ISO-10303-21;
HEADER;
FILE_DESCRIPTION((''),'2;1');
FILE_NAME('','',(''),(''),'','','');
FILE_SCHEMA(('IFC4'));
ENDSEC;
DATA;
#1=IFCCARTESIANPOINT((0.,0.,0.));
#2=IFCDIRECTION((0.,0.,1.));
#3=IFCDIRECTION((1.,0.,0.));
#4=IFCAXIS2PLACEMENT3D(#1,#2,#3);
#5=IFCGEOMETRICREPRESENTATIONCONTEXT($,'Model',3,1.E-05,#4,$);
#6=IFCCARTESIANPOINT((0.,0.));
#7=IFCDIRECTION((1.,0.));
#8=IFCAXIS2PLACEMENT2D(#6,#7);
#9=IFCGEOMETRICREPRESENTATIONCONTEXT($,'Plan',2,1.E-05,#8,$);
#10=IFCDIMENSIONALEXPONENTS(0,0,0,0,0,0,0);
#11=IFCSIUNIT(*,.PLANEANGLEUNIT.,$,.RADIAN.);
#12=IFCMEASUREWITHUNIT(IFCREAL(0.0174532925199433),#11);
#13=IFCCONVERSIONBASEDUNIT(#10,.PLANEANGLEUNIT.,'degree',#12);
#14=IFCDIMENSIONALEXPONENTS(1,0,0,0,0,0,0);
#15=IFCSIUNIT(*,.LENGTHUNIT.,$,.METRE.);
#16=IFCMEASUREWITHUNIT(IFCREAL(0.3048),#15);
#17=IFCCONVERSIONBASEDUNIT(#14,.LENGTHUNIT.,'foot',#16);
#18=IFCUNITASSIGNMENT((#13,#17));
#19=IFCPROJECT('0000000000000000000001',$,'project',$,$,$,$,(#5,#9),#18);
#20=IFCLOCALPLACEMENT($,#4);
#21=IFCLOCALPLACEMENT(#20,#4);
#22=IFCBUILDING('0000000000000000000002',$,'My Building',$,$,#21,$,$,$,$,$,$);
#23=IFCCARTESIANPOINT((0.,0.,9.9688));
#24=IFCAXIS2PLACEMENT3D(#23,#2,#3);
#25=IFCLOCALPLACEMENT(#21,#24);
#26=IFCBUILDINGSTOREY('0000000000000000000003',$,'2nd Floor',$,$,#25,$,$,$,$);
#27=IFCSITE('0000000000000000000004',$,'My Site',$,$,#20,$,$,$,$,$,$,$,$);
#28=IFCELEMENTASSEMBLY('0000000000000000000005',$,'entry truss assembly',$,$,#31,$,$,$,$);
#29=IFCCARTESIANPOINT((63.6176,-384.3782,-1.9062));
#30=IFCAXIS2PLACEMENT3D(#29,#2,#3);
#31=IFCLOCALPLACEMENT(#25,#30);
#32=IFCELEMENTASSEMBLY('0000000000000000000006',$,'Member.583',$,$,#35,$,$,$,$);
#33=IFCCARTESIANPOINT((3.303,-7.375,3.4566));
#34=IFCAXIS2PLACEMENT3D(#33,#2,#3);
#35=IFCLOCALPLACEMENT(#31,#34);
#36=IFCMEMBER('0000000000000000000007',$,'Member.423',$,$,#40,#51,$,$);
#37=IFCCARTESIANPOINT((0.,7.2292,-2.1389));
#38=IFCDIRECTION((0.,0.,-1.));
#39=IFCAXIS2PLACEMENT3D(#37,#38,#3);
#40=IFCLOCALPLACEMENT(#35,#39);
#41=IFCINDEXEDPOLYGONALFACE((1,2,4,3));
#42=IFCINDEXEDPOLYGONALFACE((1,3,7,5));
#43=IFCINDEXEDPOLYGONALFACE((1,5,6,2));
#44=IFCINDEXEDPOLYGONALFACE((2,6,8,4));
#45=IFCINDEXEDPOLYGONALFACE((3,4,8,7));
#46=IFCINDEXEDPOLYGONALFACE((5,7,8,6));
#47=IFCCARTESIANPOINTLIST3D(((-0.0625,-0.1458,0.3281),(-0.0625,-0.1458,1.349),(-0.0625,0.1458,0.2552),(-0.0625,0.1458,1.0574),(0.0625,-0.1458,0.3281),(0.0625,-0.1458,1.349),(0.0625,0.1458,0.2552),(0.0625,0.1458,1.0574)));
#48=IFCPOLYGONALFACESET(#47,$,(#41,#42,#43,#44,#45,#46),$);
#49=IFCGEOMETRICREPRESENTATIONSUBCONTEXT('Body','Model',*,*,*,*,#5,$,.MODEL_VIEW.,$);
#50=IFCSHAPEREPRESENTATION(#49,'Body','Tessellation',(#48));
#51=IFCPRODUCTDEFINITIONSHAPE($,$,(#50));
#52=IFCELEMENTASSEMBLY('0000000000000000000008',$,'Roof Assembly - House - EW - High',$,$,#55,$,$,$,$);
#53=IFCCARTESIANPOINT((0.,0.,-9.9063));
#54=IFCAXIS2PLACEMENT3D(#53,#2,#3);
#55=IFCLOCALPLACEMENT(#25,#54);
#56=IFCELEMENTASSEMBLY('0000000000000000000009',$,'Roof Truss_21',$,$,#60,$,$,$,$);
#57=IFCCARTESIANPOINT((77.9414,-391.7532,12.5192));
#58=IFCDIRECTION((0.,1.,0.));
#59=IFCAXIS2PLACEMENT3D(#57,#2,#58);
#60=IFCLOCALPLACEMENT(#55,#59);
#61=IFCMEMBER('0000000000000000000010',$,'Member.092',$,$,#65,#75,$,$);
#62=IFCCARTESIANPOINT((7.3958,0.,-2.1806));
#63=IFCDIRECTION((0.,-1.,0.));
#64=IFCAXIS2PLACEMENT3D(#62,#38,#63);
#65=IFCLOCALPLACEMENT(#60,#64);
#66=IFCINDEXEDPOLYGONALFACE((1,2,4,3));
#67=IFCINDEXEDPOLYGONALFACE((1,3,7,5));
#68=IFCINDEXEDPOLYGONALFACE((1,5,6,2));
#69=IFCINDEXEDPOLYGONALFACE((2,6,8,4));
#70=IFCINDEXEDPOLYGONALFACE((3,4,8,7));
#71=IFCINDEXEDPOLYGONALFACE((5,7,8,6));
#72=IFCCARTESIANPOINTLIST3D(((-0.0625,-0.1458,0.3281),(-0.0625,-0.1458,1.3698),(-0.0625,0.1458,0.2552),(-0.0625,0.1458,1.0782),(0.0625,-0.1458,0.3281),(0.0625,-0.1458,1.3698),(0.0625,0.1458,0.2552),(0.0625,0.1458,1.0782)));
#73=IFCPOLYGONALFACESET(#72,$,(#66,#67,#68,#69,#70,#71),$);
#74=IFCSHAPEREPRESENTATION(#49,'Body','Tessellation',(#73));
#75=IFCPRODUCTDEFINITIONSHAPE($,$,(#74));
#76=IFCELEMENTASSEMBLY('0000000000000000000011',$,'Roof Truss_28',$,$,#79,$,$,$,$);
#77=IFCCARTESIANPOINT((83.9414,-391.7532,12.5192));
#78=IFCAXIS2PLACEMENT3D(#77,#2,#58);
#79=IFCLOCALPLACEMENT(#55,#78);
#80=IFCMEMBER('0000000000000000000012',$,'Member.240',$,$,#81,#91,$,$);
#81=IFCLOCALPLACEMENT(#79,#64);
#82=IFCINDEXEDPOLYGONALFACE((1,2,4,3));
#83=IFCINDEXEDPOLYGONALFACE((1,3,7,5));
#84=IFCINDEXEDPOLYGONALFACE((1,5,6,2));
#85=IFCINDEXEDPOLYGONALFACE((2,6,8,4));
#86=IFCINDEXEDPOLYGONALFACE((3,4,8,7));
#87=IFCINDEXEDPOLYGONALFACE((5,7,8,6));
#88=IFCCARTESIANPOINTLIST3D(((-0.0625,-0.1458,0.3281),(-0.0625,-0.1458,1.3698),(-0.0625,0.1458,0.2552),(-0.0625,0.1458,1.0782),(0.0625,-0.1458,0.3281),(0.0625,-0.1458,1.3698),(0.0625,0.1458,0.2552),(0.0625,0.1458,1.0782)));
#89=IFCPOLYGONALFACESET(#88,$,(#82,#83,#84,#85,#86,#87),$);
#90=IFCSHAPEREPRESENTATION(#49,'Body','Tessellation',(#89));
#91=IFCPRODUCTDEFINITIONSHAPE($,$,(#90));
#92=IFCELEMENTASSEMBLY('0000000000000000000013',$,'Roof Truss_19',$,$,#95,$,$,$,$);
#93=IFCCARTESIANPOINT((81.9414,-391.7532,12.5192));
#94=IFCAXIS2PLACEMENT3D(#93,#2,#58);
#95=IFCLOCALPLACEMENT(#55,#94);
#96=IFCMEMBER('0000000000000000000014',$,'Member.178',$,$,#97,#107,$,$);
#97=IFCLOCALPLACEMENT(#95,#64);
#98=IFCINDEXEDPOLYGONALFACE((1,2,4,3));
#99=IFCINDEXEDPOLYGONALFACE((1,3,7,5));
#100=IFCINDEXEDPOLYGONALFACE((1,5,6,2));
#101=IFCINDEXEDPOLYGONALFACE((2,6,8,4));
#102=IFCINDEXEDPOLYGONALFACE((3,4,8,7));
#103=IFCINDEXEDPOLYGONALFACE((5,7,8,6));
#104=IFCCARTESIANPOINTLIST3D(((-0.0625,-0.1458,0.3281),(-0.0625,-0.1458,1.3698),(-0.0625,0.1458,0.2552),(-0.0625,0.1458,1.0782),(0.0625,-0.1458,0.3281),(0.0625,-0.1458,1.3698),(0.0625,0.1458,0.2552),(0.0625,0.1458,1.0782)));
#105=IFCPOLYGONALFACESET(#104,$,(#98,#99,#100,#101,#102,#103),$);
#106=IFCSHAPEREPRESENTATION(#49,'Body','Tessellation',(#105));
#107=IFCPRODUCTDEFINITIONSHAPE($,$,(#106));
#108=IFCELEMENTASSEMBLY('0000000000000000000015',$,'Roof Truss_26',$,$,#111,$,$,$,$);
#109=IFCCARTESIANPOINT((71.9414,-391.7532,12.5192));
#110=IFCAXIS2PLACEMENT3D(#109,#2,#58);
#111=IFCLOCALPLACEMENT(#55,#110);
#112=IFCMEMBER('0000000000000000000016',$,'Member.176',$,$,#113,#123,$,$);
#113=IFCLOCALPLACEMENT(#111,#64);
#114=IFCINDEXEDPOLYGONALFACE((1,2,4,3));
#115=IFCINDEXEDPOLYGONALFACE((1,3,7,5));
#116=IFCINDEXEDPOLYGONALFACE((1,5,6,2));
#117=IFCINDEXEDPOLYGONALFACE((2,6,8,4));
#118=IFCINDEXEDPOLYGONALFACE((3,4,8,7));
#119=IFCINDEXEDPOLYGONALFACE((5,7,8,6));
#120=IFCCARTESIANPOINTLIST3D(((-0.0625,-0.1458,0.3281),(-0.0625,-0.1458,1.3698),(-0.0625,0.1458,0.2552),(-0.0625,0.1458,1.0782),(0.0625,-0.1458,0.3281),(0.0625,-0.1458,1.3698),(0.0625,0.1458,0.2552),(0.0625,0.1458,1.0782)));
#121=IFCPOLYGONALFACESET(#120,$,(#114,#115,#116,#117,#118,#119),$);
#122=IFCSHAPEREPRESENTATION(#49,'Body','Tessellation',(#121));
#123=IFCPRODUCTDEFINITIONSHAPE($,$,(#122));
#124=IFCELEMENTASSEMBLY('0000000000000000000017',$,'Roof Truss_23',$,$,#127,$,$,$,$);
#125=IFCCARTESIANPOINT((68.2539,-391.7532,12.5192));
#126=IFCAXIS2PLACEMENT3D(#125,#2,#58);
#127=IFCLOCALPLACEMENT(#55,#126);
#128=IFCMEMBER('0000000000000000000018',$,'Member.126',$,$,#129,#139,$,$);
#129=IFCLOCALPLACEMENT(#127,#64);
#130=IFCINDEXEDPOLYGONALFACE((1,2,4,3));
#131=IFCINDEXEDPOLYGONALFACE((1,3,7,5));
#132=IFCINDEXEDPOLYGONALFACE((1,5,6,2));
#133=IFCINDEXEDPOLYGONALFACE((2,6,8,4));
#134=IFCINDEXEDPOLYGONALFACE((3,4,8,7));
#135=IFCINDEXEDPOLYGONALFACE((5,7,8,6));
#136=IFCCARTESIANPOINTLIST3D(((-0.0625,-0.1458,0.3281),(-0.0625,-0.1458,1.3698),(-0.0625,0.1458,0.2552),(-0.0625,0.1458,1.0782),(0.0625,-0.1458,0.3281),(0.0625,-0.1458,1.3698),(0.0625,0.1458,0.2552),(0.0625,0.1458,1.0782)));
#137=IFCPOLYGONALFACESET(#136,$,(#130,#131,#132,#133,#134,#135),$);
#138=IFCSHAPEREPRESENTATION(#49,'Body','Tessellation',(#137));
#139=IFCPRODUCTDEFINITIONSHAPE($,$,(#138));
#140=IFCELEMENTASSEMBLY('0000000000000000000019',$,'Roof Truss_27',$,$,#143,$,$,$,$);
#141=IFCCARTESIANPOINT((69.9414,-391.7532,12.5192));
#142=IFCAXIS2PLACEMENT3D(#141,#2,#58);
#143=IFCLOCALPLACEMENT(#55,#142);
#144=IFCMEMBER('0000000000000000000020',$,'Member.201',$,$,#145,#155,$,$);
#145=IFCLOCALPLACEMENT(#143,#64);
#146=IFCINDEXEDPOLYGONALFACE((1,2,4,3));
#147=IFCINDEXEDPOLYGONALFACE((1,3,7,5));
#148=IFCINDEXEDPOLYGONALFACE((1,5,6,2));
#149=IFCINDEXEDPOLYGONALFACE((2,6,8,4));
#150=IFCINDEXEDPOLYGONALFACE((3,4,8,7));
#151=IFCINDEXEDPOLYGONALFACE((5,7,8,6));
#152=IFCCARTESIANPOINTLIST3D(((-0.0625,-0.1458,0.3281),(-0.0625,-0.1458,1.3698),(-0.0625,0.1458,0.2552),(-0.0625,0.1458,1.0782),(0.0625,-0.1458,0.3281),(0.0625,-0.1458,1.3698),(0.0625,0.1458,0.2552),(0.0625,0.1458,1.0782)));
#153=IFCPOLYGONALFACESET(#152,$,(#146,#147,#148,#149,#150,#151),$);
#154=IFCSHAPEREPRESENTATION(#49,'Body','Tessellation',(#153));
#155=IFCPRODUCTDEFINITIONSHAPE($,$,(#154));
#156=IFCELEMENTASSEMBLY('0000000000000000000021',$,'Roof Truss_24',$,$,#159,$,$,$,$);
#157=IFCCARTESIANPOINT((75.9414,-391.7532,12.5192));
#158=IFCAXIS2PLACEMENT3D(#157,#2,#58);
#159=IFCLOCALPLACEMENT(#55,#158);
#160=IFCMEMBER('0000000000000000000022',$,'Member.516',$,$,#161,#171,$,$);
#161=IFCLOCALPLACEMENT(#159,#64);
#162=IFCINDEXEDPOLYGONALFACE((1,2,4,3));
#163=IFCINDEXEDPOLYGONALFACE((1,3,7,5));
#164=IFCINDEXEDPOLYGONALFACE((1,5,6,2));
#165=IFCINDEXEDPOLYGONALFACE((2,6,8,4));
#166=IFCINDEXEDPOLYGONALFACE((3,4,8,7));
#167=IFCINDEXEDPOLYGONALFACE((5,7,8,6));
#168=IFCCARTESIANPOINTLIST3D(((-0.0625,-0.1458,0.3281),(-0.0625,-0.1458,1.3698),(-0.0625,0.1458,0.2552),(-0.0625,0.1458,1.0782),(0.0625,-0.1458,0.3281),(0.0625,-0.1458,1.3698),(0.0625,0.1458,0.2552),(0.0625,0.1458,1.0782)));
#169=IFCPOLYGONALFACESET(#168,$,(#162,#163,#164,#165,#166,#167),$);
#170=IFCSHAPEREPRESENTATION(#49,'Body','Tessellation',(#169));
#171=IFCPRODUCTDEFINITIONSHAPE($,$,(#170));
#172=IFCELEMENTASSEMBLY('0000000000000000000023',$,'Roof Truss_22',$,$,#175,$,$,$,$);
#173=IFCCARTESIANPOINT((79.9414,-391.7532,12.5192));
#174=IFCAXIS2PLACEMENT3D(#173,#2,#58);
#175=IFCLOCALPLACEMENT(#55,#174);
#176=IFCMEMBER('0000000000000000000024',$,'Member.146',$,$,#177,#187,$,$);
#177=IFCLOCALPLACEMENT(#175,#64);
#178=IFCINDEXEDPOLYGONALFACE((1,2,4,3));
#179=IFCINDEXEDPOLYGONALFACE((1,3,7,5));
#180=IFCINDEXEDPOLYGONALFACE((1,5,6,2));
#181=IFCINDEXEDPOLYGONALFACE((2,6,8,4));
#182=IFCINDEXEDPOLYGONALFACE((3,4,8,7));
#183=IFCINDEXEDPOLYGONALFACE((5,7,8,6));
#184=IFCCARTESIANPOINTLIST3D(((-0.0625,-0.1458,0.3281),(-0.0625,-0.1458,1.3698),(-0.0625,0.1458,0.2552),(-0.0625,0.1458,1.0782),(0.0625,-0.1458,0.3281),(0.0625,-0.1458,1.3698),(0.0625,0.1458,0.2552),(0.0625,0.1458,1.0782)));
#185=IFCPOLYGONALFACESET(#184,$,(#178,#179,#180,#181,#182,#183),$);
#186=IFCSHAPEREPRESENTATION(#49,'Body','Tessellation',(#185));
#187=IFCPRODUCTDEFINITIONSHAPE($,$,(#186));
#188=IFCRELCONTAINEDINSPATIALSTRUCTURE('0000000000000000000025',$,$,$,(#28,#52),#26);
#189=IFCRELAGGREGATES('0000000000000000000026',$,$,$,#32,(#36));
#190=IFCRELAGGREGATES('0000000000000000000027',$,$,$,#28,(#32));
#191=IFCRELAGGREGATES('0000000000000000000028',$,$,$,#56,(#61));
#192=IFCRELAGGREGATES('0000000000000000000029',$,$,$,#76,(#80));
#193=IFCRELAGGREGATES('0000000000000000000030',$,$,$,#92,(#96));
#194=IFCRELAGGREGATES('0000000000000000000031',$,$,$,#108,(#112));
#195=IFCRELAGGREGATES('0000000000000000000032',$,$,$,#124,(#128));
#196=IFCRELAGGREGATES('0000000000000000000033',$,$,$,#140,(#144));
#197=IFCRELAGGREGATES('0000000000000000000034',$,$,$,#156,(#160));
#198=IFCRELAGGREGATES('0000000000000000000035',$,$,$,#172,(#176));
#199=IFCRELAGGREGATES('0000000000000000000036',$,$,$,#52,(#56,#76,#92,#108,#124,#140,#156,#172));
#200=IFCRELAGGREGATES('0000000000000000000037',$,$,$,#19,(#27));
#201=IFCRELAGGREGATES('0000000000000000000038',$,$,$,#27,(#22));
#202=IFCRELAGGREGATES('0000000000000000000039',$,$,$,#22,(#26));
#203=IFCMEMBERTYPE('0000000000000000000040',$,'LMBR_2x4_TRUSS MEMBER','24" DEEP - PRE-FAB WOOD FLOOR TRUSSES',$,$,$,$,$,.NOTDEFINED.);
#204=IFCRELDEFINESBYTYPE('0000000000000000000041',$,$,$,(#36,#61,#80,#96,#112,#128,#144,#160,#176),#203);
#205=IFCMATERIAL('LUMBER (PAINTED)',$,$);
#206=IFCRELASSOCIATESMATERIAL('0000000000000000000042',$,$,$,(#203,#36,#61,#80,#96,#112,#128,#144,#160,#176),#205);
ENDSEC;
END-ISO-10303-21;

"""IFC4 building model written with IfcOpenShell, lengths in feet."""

from ifc_helpers import new_model, entity, si_unit, converted_unit, frame, origin_with_axes, origin_2d_with_axis, place, context, subcontext, project, spatial, indexed_curve, outline, extrude, clip, halfspace, material, material_profile, profile_set, profile_usage, type_object, element, aggregate, save


model = new_model("IFC4")

# Units and contexts
model_context = context("Model", 3, precision=1e-05, world=origin_with_axes())
plan_context = context("Plan", 2, precision=1e-05, world=origin_2d_with_axis())
body_context = subcontext(model_context, "Body", "Model", "MODEL_VIEW")
ifc_project = project(units=[converted_unit("PLANEANGLEUNIT", "degree", entity("IfcReal", 0.0174532925199433), si_unit("PLANEANGLEUNIT", "RADIAN"), dimensions=[0, 0, 0, 0, 0, 0, 0]), converted_unit("LENGTHUNIT", "foot", entity("IfcReal", 0.3048), si_unit("LENGTHUNIT", "METRE"), dimensions=[1, 0, 0, 0, 0, 0, 0])], contexts=[model_context, plan_context])

# Site, building, storey
site_placement = place(None, origin_with_axes())
site = spatial("IfcSite", under=ifc_project, at=site_placement, Name="My Site")
building_placement = place(site_placement, origin_with_axes())
building = spatial("IfcBuilding", under=site, at=building_placement, Name="My Building")
storey_placement = place(building_placement, frame((0.0, 0.0, 9.9688), z_axis=(0.0, 0.0, 1.0), x_axis=(1.0, 0.0, 0.0)))
storey = spatial("IfcBuildingStorey", under=building, at=storey_placement, Name="2nd Floor")

# Element assemblies, members
assembly_1_placement = place(storey_placement, frame((63.6176, -384.3782, -1.9062), z_axis=(0.0, 0.0, 1.0), x_axis=(1.0, 0.0, 0.0)))
assembly_1 = element("IfcElementAssembly", 1, at=assembly_1_placement, inside=storey, Name="entry truss assembly")
assembly_2_placement = place(assembly_1_placement, frame((3.303, -7.375, 3.4566), z_axis=(0.0, 0.0, 1.0), x_axis=(1.0, 0.0, 0.0)))
assembly_2 = element("IfcElementAssembly", 2, at=assembly_2_placement, Name="Member.583")
ifc_material_1 = material(Name="LUMBER (PAINTED)")
ifc_material_profile_1 = material_profile(ifc_material_1, outline(indexed_curve([(-0.0625, -0.1458), (0.0625, -0.1458), (0.0625, 0.1458), (-0.0625, 0.1458), (-0.0625, -0.1458)])))
ifc_profile_set_1 = profile_set([ifc_material_profile_1])
member_type_1 = type_object("IfcMemberType", Name="LMBR_2x4_TRUSS MEMBER", Description="24\" DEEP - PRE-FAB WOOD FLOOR TRUSSES", PredefinedType="NOTDEFINED", material=ifc_profile_set_1)
ifc_profile_usage_1 = profile_usage(ifc_profile_set_1)
member_1_placement = place(assembly_2_placement, frame((0.0, 7.2292, -2.1389), z_axis=(0.0, 0.0, -1.0), x_axis=(1.0, 0.0, 0.0)))
member_1 = element("IfcMember", 3, at=member_1_placement, type_object=member_type_1, material=ifc_profile_usage_1, Name="Member.423", context=body_context, shape_type="Clipping", body=[
    clip(clip(extrude(outline(indexed_curve([(-0.0625, -0.1458), (0.0625, -0.1458), (0.0625, 0.1458), (-0.0625, 0.1458), (-0.0625, -0.1458)])), origin_with_axes(), (0.0, 0.0, 1.0), 1.349), halfspace(frame((0.0, 7.3757, -1.5528), z_axis=(0.0, -0.242599, -0.970127), x_axis=(-1.0, 0.0, 0.0)), False)), halfspace(frame((-66.9205, -0.1458, 1.349), z_axis=(0.0, 0.707116, 0.707097), x_axis=(1.0, 0.0, 0.0)), False)),
])
aggregate(assembly_2, [member_1])
aggregate(assembly_1, [assembly_2])
assembly_3_placement = place(storey_placement, frame((0.0, 0.0, -9.9063), z_axis=(0.0, 0.0, 1.0), x_axis=(1.0, 0.0, 0.0)))
assembly_3 = element("IfcElementAssembly", 4, at=assembly_3_placement, inside=storey, Name="Roof Assembly - House - EW - High")
assembly_4_placement = place(assembly_3_placement, frame((77.9414, -391.7532, 12.5192), z_axis=(0.0, 0.0, 1.0), x_axis=(0.0, 1.0, 0.0)))
assembly_4 = element("IfcElementAssembly", 5, at=assembly_4_placement, Name="Roof Truss_21")
ifc_profile_usage_2 = profile_usage(ifc_profile_set_1)
member_2_placement = place(assembly_4_placement, frame((7.3958, 0.0, -2.1806), z_axis=(0.0, 0.0, -1.0), x_axis=(0.0, -1.0, 0.0)))
member_2 = element("IfcMember", 6, at=member_2_placement, type_object=member_type_1, material=ifc_profile_usage_2, Name="Member.092", context=body_context, shape_type="Clipping", body=[
    clip(clip(extrude(outline(indexed_curve([(-0.0625, -0.1458), (0.0625, -0.1458), (0.0625, 0.1458), (-0.0625, 0.1458), (-0.0625, -0.1458)])), origin_with_axes(), (0.0, 0.0, 1.0), 1.3698), halfspace(frame((0.0, 7.5424, -1.5944), z_axis=(0.0, -0.242599, -0.970127), x_axis=(-1.0, 0.0, 0.0)), False)), halfspace(frame((-397.5032, -0.1458, 1.3698), z_axis=(0.0, 0.707099, 0.707114), x_axis=(1.0, 0.0, 0.0)), False)),
])
aggregate(assembly_4, [member_2])
assembly_5_placement = place(assembly_3_placement, frame((83.9414, -391.7532, 12.5192), z_axis=(0.0, 0.0, 1.0), x_axis=(0.0, 1.0, 0.0)))
assembly_5 = element("IfcElementAssembly", 7, at=assembly_5_placement, Name="Roof Truss_28")
ifc_profile_usage_3 = profile_usage(ifc_profile_set_1)
member_3_placement = place(assembly_5_placement, frame((7.3958, 0.0, -2.1806), z_axis=(0.0, 0.0, -1.0), x_axis=(0.0, -1.0, 0.0)))
member_3 = element("IfcMember", 8, at=member_3_placement, type_object=member_type_1, material=ifc_profile_usage_3, Name="Member.240", context=body_context, shape_type="Clipping", body=[
    clip(clip(extrude(outline(indexed_curve([(-0.0625, -0.1458), (0.0625, -0.1458), (0.0625, 0.1458), (-0.0625, 0.1458), (-0.0625, -0.1458)])), origin_with_axes(), (0.0, 0.0, 1.0), 1.3698), halfspace(frame((0.0, 7.5424, -1.5944), z_axis=(0.0, -0.242599, -0.970127), x_axis=(-1.0, 0.0, 0.0)), False)), halfspace(frame((-397.5032, -0.1458, 1.3698), z_axis=(0.0, 0.707099, 0.707114), x_axis=(1.0, 0.0, 0.0)), False)),
])
aggregate(assembly_5, [member_3])
assembly_6_placement = place(assembly_3_placement, frame((81.9414, -391.7532, 12.5192), z_axis=(0.0, 0.0, 1.0), x_axis=(0.0, 1.0, 0.0)))
assembly_6 = element("IfcElementAssembly", 9, at=assembly_6_placement, Name="Roof Truss_19")
ifc_profile_usage_4 = profile_usage(ifc_profile_set_1)
member_4_placement = place(assembly_6_placement, frame((7.3958, 0.0, -2.1806), z_axis=(0.0, 0.0, -1.0), x_axis=(0.0, -1.0, 0.0)))
member_4 = element("IfcMember", 10, at=member_4_placement, type_object=member_type_1, material=ifc_profile_usage_4, Name="Member.178", context=body_context, shape_type="Clipping", body=[
    clip(clip(extrude(outline(indexed_curve([(-0.0625, -0.1458), (0.0625, -0.1458), (0.0625, 0.1458), (-0.0625, 0.1458), (-0.0625, -0.1458)])), origin_with_axes(), (0.0, 0.0, 1.0), 1.3698), halfspace(frame((0.0, 7.5424, -1.5944), z_axis=(0.0, -0.242599, -0.970127), x_axis=(-1.0, 0.0, 0.0)), False)), halfspace(frame((-397.5032, -0.1458, 1.3698), z_axis=(0.0, 0.707099, 0.707114), x_axis=(1.0, 0.0, 0.0)), False)),
])
aggregate(assembly_6, [member_4])
assembly_7_placement = place(assembly_3_placement, frame((71.9414, -391.7532, 12.5192), z_axis=(0.0, 0.0, 1.0), x_axis=(0.0, 1.0, 0.0)))
assembly_7 = element("IfcElementAssembly", 11, at=assembly_7_placement, Name="Roof Truss_26")
ifc_profile_usage_5 = profile_usage(ifc_profile_set_1)
member_5_placement = place(assembly_7_placement, frame((7.3958, 0.0, -2.1806), z_axis=(0.0, 0.0, -1.0), x_axis=(0.0, -1.0, 0.0)))
member_5 = element("IfcMember", 12, at=member_5_placement, type_object=member_type_1, material=ifc_profile_usage_5, Name="Member.176", context=body_context, shape_type="Clipping", body=[
    clip(clip(extrude(outline(indexed_curve([(-0.0625, -0.1458), (0.0625, -0.1458), (0.0625, 0.1458), (-0.0625, 0.1458), (-0.0625, -0.1458)])), origin_with_axes(), (0.0, 0.0, 1.0), 1.3698), halfspace(frame((0.0, 7.5424, -1.5944), z_axis=(0.0, -0.242599, -0.970127), x_axis=(-1.0, 0.0, 0.0)), False)), halfspace(frame((-397.5032, -0.1458, 1.3698), z_axis=(0.0, 0.707099, 0.707114), x_axis=(1.0, 0.0, 0.0)), False)),
])
aggregate(assembly_7, [member_5])
assembly_8_placement = place(assembly_3_placement, frame((68.2539, -391.7532, 12.5192), z_axis=(0.0, 0.0, 1.0), x_axis=(0.0, 1.0, 0.0)))
assembly_8 = element("IfcElementAssembly", 13, at=assembly_8_placement, Name="Roof Truss_23")
ifc_profile_usage_6 = profile_usage(ifc_profile_set_1)
member_6_placement = place(assembly_8_placement, frame((7.3958, 0.0, -2.1806), z_axis=(0.0, 0.0, -1.0), x_axis=(0.0, -1.0, 0.0)))
member_6 = element("IfcMember", 14, at=member_6_placement, type_object=member_type_1, material=ifc_profile_usage_6, Name="Member.126", context=body_context, shape_type="Clipping", body=[
    clip(clip(extrude(outline(indexed_curve([(-0.0625, -0.1458), (0.0625, -0.1458), (0.0625, 0.1458), (-0.0625, 0.1458), (-0.0625, -0.1458)])), origin_with_axes(), (0.0, 0.0, 1.0), 1.3698), halfspace(frame((0.0, 7.5424, -1.5944), z_axis=(0.0, -0.242599, -0.970127), x_axis=(-1.0, 0.0, 0.0)), False)), halfspace(frame((-397.5032, -0.1458, 1.3698), z_axis=(0.0, 0.707099, 0.707114), x_axis=(1.0, 0.0, 0.0)), False)),
])
aggregate(assembly_8, [member_6])
assembly_9_placement = place(assembly_3_placement, frame((69.9414, -391.7532, 12.5192), z_axis=(0.0, 0.0, 1.0), x_axis=(0.0, 1.0, 0.0)))
assembly_9 = element("IfcElementAssembly", 15, at=assembly_9_placement, Name="Roof Truss_27")
ifc_profile_usage_7 = profile_usage(ifc_profile_set_1)
member_7_placement = place(assembly_9_placement, frame((7.3958, 0.0, -2.1806), z_axis=(0.0, 0.0, -1.0), x_axis=(0.0, -1.0, 0.0)))
member_7 = element("IfcMember", 16, at=member_7_placement, type_object=member_type_1, material=ifc_profile_usage_7, Name="Member.201", context=body_context, shape_type="Clipping", body=[
    clip(clip(extrude(outline(indexed_curve([(-0.0625, -0.1458), (0.0625, -0.1458), (0.0625, 0.1458), (-0.0625, 0.1458), (-0.0625, -0.1458)])), origin_with_axes(), (0.0, 0.0, 1.0), 1.3698), halfspace(frame((0.0, 7.5424, -1.5944), z_axis=(0.0, -0.242599, -0.970127), x_axis=(-1.0, 0.0, 0.0)), False)), halfspace(frame((-397.5032, -0.1458, 1.3698), z_axis=(0.0, 0.707099, 0.707114), x_axis=(1.0, 0.0, 0.0)), False)),
])
aggregate(assembly_9, [member_7])
assembly_10_placement = place(assembly_3_placement, frame((75.9414, -391.7532, 12.5192), z_axis=(0.0, 0.0, 1.0), x_axis=(0.0, 1.0, 0.0)))
assembly_10 = element("IfcElementAssembly", 17, at=assembly_10_placement, Name="Roof Truss_24")
ifc_profile_usage_8 = profile_usage(ifc_profile_set_1)
member_8_placement = place(assembly_10_placement, frame((7.3958, 0.0, -2.1806), z_axis=(0.0, 0.0, -1.0), x_axis=(0.0, -1.0, 0.0)))
member_8 = element("IfcMember", 18, at=member_8_placement, type_object=member_type_1, material=ifc_profile_usage_8, Name="Member.516", context=body_context, shape_type="Clipping", body=[
    clip(clip(extrude(outline(indexed_curve([(-0.0625, -0.1458), (0.0625, -0.1458), (0.0625, 0.1458), (-0.0625, 0.1458), (-0.0625, -0.1458)])), origin_with_axes(), (0.0, 0.0, 1.0), 1.3698), halfspace(frame((0.0, 7.5424, -1.5944), z_axis=(0.0, -0.242599, -0.970127), x_axis=(-1.0, 0.0, 0.0)), False)), halfspace(frame((-397.5032, -0.1458, 1.3698), z_axis=(0.0, 0.707099, 0.707114), x_axis=(1.0, 0.0, 0.0)), False)),
])
aggregate(assembly_10, [member_8])
assembly_11_placement = place(assembly_3_placement, frame((79.9414, -391.7532, 12.5192), z_axis=(0.0, 0.0, 1.0), x_axis=(0.0, 1.0, 0.0)))
assembly_11 = element("IfcElementAssembly", 19, at=assembly_11_placement, Name="Roof Truss_22")
ifc_profile_usage_9 = profile_usage(ifc_profile_set_1)
member_9_placement = place(assembly_11_placement, frame((7.3958, 0.0, -2.1806), z_axis=(0.0, 0.0, -1.0), x_axis=(0.0, -1.0, 0.0)))
member_9 = element("IfcMember", 20, at=member_9_placement, type_object=member_type_1, material=ifc_profile_usage_9, Name="Member.146", context=body_context, shape_type="Clipping", body=[
    clip(clip(extrude(outline(indexed_curve([(-0.0625, -0.1458), (0.0625, -0.1458), (0.0625, 0.1458), (-0.0625, 0.1458), (-0.0625, -0.1458)])), origin_with_axes(), (0.0, 0.0, 1.0), 1.3698), halfspace(frame((0.0, 7.5424, -1.5944), z_axis=(0.0, -0.242599, -0.970127), x_axis=(-1.0, 0.0, 0.0)), False)), halfspace(frame((-397.5032, -0.1458, 1.3698), z_axis=(0.0, 0.707099, 0.707114), x_axis=(1.0, 0.0, 0.0)), False)),
])
aggregate(assembly_11, [member_9])

aggregate(assembly_3, [assembly_4, assembly_5, assembly_6, assembly_7, assembly_8, assembly_9, assembly_10, assembly_11])

save(model, "model.ifc")
